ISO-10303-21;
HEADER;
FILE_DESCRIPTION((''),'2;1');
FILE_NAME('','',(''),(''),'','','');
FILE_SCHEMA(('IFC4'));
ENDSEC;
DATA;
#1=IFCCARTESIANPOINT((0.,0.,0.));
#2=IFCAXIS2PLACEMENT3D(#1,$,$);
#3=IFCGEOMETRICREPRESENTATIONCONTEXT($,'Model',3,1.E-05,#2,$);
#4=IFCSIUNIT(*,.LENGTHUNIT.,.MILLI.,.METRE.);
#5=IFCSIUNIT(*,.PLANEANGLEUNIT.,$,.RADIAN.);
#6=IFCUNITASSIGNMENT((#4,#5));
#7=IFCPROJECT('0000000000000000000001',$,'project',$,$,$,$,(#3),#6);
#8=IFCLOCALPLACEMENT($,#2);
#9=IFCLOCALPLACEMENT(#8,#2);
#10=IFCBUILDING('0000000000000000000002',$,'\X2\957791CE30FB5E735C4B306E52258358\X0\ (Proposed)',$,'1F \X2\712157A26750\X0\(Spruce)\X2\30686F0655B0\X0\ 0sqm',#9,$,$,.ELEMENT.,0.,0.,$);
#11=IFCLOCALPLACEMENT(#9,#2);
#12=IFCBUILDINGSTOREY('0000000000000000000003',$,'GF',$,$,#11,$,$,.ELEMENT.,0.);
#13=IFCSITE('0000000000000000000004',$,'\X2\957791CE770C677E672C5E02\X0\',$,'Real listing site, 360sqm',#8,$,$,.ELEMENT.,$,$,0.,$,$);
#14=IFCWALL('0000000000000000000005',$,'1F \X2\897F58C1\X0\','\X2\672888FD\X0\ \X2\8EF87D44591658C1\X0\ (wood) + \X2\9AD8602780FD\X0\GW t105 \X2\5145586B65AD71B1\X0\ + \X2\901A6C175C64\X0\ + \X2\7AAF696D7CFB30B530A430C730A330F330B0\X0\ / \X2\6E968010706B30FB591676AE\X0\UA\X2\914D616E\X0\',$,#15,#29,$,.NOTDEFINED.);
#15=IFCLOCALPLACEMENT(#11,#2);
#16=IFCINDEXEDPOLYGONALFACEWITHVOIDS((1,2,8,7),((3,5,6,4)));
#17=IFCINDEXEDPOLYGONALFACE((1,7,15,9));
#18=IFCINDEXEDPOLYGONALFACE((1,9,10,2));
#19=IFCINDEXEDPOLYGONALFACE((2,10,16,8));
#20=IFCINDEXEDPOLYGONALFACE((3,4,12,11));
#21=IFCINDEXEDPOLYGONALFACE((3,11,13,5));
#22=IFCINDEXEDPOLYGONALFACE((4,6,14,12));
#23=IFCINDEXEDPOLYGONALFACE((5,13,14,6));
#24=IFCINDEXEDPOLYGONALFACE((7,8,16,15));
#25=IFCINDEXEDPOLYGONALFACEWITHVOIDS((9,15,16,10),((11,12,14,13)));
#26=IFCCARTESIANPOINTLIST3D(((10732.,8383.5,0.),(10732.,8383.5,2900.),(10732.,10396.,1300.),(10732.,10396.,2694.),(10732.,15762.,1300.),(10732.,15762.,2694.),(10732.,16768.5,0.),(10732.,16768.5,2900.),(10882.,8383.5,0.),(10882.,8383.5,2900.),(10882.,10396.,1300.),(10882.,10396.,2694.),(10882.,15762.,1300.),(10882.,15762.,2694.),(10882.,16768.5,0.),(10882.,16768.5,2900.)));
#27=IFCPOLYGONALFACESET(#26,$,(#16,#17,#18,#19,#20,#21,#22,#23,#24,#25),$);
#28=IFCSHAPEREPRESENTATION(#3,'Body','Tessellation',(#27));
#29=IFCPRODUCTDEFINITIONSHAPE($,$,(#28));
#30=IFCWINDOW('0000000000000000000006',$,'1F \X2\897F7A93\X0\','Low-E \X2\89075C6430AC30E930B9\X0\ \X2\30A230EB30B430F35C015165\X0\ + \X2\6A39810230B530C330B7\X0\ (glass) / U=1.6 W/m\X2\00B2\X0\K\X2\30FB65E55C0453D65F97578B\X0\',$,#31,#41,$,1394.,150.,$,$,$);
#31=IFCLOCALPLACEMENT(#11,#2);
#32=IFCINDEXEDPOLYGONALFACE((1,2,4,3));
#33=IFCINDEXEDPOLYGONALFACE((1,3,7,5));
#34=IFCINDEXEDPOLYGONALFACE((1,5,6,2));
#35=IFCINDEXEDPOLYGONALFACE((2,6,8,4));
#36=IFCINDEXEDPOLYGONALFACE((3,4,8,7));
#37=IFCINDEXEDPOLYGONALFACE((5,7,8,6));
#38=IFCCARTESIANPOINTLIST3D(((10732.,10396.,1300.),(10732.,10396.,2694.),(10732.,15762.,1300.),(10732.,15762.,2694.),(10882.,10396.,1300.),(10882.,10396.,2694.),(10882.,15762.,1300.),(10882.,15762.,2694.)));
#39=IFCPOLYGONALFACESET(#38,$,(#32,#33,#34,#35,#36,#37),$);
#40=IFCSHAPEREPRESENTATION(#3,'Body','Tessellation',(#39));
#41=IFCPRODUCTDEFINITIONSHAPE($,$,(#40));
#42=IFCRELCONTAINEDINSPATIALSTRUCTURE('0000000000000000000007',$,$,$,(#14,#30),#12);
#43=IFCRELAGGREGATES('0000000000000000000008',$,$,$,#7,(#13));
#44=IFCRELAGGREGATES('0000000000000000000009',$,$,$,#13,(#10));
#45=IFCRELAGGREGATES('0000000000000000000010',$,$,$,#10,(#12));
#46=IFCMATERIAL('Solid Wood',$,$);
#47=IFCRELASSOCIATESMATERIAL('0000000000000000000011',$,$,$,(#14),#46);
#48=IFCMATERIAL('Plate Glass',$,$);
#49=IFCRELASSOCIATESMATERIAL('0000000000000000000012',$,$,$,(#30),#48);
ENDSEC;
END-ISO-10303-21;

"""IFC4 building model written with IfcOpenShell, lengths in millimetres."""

from ifc_helpers import new_model, si_unit, frame, frame_2d, origin, place, context, project, spatial, rectangle, extrude, material, element, fill, save


model = new_model("IFC4")

# Units and contexts
model_context = context("Model", 3, precision=1e-05, world=origin())
ifc_project = project(units=[si_unit("LENGTHUNIT", "METRE", prefix="MILLI"), si_unit("PLANEANGLEUNIT", "RADIAN")], contexts=[model_context])

# Site, building, storey
site_placement = place(None, origin())
site = spatial("IfcSite", under=ifc_project, at=site_placement, Name="長野県松本市", ObjectType="Real listing site, 360sqm", CompositionType="ELEMENT", RefElevation=0.0)
building_placement = place(site_placement, origin())
building = spatial("IfcBuilding", under=site, at=building_placement, Name="長野・平屋の別荘 (Proposed)", ObjectType="1F 無垢材(Spruce)と漆喰 0sqm", CompositionType="ELEMENT", ElevationOfRefHeight=0.0, ElevationOfTerrain=0.0)
storey_placement = place(building_placement, origin())
storey = spatial("IfcBuildingStorey", under=building, at=storey_placement, Name="GF", CompositionType="ELEMENT", Elevation=0.0)

# Shared definitions
ifc_material_1 = material(Name="Solid Wood")

# Shared definitions
ifc_material_2 = material(Name="Plate Glass")

# Wall, opening, window
wall_1_placement = place(storey_placement, frame((5366.0, 4192.0, 0.0)))
wall_1 = element("IfcWall", 1, at=wall_1_placement, inside=storey, material=ifc_material_1, Name="1F 西壁", Description="木製 軸組外壁 (wood) + 高性能GW t105 充填断熱 + 通気層 + 窯業系サイディング / 準耐火・外皮UA配慮", PredefinedType="NOTDEFINED", context=model_context, shape_type="SweptSolid", body=[
    extrude(rectangle(XDim=150.0, YDim=8385.0, at=frame_2d((75.0, 4192.0))), frame((5366.0, 4192.0, 0.0)), (0.0, 0.0, 1.0), 2900.0),
])
opening_1_placement = place(storey_placement, frame((5366.0, 5198.0, 650.0)))
opening_1 = element("IfcOpeningElement", 2, at=opening_1_placement, cuts=wall_1, PredefinedType="NOTDEFINED", context=model_context, shape_type="SweptSolid", body=[
    extrude(rectangle(XDim=150.0, YDim=5366.0, at=frame_2d((75.0, 2683.0))), frame((5366.0, 5198.0, 650.0)), (0.0, 0.0, 1.0), 1394.0),
])
window_1_placement = place(storey_placement, frame((5366.0, 5198.0, 650.0)))
window_1 = element("IfcWindow", 3, at=window_1_placement, inside=storey, material=ifc_material_2, Name="1F 西窓", Description="Low-E 複層ガラス アルゴン封入 + 樹脂サッシ (glass) / U=1.6 W/m²K・日射取得型", OverallHeight=1394.0, OverallWidth=150.0, context=model_context, shape_type="SweptSolid", body=[
    extrude(rectangle(XDim=150.0, YDim=5366.0, at=frame_2d((75.0, 2683.0))), frame((5366.0, 5198.0, 650.0)), (0.0, 0.0, 1.0), 1394.0),
])
fill(opening_1, window_1)

save(model, "model.ifc")
